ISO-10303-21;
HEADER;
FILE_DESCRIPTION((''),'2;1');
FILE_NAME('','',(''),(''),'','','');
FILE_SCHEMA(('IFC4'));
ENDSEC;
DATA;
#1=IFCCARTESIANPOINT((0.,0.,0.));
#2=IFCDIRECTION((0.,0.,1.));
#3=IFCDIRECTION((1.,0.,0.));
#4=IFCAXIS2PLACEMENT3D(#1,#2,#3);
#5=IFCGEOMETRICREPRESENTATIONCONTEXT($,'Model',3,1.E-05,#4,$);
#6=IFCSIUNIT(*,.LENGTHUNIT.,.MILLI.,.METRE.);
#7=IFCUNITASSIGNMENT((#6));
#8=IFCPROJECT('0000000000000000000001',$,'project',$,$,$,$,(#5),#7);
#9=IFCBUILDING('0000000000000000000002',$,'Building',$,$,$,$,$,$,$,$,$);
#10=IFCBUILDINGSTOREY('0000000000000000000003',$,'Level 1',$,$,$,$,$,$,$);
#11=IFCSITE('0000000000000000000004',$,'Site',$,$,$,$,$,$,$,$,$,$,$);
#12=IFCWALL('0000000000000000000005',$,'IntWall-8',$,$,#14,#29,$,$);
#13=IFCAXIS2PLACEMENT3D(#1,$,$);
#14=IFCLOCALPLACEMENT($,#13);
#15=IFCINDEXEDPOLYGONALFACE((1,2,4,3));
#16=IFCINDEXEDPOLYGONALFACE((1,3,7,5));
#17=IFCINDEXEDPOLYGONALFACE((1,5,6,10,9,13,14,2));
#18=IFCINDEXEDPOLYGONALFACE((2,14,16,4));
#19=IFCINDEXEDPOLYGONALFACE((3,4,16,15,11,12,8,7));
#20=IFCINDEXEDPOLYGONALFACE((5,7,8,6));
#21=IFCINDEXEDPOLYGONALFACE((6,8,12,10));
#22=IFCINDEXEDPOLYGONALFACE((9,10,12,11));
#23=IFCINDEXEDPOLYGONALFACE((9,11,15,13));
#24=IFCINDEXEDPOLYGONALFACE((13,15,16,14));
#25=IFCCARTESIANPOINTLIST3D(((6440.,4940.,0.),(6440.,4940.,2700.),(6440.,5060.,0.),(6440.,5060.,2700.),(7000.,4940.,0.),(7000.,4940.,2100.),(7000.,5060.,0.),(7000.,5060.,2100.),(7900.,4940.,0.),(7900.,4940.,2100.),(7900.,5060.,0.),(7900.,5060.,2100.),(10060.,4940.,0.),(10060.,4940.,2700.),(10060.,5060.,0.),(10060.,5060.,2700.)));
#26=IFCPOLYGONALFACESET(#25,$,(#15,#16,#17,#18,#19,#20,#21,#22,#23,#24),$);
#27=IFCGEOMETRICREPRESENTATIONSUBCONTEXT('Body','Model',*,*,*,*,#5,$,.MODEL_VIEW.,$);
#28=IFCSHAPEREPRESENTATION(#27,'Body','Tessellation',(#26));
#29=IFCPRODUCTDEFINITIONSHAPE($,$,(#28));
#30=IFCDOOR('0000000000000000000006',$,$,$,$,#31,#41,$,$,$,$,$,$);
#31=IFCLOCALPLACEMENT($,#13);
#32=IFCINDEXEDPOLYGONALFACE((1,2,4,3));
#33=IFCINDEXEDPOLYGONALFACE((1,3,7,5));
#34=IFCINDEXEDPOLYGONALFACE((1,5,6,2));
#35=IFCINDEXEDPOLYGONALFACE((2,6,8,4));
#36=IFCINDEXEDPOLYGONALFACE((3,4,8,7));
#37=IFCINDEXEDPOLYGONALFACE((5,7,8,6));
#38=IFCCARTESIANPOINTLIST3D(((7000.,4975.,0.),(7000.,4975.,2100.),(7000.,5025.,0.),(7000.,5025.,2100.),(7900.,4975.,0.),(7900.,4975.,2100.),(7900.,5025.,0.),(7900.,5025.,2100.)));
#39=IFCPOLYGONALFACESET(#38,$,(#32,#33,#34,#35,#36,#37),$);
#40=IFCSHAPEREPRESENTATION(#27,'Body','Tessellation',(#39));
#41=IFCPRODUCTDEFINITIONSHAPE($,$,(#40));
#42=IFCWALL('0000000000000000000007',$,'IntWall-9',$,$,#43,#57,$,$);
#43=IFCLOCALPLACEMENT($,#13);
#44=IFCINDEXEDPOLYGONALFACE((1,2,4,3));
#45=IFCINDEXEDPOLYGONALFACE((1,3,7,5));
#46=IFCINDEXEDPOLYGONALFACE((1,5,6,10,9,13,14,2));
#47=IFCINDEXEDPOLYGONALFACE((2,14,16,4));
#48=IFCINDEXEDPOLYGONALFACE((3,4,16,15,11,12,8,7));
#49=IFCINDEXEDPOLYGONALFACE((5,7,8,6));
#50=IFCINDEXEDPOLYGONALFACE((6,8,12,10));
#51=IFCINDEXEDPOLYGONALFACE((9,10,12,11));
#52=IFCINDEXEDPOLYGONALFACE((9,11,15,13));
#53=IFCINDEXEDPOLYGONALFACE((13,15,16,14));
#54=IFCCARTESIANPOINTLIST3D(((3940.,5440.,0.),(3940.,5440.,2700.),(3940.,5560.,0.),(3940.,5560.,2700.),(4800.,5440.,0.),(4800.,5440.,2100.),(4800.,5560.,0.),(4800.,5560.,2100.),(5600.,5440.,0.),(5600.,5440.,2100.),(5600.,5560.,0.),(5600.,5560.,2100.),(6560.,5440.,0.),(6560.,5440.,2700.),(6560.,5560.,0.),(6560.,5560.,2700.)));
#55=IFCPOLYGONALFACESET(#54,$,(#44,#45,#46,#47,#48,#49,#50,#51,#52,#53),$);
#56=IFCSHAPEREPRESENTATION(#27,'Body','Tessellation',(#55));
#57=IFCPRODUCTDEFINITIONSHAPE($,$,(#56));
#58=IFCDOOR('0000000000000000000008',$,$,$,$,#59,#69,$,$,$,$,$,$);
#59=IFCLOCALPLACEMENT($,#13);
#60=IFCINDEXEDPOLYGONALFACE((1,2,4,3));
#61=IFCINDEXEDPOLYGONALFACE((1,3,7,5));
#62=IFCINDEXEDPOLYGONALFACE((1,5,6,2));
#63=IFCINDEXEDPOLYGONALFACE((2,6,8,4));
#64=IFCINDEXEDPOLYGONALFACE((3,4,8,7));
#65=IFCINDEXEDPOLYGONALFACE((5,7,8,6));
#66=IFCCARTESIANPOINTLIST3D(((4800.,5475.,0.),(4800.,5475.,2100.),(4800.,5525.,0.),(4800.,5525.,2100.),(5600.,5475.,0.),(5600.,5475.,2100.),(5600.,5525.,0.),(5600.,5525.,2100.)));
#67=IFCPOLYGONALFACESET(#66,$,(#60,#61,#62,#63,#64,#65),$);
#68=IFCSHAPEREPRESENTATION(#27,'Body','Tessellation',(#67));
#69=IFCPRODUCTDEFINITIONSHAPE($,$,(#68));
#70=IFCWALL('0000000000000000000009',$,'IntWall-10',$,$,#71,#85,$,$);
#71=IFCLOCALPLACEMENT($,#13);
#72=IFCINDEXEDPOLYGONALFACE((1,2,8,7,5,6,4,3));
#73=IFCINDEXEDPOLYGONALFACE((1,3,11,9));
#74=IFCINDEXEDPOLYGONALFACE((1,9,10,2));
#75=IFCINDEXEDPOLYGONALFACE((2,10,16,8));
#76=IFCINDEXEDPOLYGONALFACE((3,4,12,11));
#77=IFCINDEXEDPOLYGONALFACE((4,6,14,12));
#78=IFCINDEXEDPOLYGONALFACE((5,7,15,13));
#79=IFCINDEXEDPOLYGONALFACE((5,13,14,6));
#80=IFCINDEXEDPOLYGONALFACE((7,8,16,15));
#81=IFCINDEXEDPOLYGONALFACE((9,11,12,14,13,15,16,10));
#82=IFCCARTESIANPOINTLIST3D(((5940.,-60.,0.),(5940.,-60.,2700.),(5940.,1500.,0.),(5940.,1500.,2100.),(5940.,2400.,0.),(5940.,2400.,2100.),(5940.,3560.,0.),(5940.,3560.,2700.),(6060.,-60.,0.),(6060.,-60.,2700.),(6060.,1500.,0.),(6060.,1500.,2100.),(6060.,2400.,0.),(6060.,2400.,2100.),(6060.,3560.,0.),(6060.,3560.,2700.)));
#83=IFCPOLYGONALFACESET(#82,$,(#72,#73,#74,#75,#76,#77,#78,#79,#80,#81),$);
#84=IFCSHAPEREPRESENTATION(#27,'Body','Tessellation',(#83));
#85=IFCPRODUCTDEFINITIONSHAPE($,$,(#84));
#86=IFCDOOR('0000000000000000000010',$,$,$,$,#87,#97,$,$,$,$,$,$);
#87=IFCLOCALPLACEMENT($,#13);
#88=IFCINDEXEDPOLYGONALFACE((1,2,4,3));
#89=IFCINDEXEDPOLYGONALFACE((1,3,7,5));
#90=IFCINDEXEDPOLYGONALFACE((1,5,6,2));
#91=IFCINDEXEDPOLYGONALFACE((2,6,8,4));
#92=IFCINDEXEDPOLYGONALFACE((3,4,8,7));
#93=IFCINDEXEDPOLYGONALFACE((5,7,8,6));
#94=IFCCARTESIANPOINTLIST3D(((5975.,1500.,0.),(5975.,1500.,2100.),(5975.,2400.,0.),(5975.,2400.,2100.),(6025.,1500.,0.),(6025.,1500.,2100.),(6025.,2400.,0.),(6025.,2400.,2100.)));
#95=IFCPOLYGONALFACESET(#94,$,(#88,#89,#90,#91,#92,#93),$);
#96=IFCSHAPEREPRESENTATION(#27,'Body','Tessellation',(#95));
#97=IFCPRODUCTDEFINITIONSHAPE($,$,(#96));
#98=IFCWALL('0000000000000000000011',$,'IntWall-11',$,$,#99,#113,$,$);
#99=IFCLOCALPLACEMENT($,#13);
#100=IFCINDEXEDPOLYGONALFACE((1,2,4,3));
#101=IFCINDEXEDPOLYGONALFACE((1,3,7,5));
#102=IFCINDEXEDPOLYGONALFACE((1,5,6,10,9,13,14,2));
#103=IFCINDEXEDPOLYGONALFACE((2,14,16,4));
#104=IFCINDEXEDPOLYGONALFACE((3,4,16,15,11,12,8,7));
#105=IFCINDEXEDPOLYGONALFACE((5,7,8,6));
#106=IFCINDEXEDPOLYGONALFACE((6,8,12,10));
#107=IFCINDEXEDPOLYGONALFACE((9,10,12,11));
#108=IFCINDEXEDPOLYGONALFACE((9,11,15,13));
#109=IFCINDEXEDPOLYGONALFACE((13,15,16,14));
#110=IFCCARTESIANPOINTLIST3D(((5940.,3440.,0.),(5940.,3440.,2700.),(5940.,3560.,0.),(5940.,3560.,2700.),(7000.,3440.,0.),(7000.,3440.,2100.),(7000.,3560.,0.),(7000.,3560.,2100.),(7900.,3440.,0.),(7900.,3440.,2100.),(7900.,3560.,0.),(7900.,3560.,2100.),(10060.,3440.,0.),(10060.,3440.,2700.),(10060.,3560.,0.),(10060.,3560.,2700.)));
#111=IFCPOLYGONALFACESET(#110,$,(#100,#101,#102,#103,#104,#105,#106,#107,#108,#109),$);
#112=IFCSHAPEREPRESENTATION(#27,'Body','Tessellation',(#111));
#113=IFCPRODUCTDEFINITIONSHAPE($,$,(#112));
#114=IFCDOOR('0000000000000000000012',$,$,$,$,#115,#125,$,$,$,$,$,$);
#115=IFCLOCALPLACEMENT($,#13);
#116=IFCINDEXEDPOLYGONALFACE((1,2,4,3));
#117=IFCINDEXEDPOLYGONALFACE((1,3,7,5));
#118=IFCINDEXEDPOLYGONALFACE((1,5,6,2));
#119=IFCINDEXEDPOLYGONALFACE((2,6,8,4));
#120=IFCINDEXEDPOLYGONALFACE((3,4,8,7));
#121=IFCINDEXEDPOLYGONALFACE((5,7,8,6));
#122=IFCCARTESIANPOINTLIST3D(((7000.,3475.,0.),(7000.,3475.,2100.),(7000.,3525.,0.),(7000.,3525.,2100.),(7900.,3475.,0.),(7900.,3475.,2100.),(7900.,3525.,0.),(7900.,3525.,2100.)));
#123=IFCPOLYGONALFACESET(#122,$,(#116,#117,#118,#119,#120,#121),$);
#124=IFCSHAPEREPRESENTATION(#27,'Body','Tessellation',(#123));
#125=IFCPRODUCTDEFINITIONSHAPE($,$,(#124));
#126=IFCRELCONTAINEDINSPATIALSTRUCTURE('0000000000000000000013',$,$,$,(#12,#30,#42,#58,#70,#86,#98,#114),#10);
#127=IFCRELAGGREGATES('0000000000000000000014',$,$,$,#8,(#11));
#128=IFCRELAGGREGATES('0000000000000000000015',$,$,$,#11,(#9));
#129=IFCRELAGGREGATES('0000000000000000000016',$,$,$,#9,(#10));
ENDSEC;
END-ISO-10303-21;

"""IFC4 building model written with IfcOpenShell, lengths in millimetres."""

from ifc_helpers import new_model, si_unit, frame, origin_with_axes, place, context, subcontext, project, spatial, indexed_curve, outline, extrude, element, fill, save


model = new_model("IFC4")

# Units and contexts
model_context = context("Model", 3, precision=1e-05, world=origin_with_axes())
body_context = subcontext(model_context, "Body", "Model", "MODEL_VIEW")
ifc_project = project(units=[si_unit("LENGTHUNIT", "METRE", prefix="MILLI")], contexts=[model_context])

# Site, building, storey
site = spatial("IfcSite", under=ifc_project, Name="Site")
building = spatial("IfcBuilding", under=site, Name="Building")
storey = spatial("IfcBuildingStorey", under=building, Name="Level 1")

# Walls, openings, doors
wall_1_placement = place(None, frame((6440.0, 5000.0, 0.0), z_axis=(0.0, 0.0, 1.0), x_axis=(1.0, 0.0, 0.0)))
wall_1 = element("IfcWall", 1, at=wall_1_placement, inside=storey, Name="IntWall-8", context=body_context, shape_type="SweptSolid", body=[
    extrude(outline(indexed_curve([(0.0, 0.0), (0.0, 120.0), (3620.0, 120.0), (3620.0, 0.0), (0.0, 0.0)], self_intersect=False)), frame((0.0, -60.0, 0.0), z_axis=(0.0, 0.0, 1.0), x_axis=(1.0, 0.0, 0.0)), (0.0, 0.0, 1.0), 2700.0),
])
opening_1_placement = place(wall_1_placement, frame((560.0, 0.0, 0.0), z_axis=(0.0, 0.0, 1.0), x_axis=(1.0, 0.0, 0.0)))
opening_1 = element("IfcOpeningElement", 2, at=opening_1_placement, cuts=wall_1, context=body_context, shape_type="SweptSolid", body=[
    extrude(outline(indexed_curve([(0.0, 0.0), (0.0, 220.0), (900.0, 220.0), (900.0, 0.0), (0.0, 0.0)], self_intersect=False)), frame((0.0, -110.0, 0.0), z_axis=(0.0, 0.0, 1.0), x_axis=(1.0, 0.0, 0.0)), (0.0, 0.0, 1.0), 2100.0),
])
door_1_placement = place(opening_1_placement, origin_with_axes())
door_1 = element("IfcDoor", 3, at=door_1_placement, inside=storey, context=body_context, shape_type="SweptSolid", body=[
    extrude(outline(indexed_curve([(0.0, 0.0), (0.0, 50.0), (900.0, 50.0), (900.0, 0.0), (0.0, 0.0)], self_intersect=False)), frame((0.0, -25.0, 0.0), z_axis=(0.0, 0.0, 1.0), x_axis=(1.0, 0.0, 0.0)), (0.0, 0.0, 1.0), 2100.0),
])
fill(opening_1, door_1)
wall_2_placement = place(None, frame((3940.0, 5500.0, 0.0), z_axis=(0.0, 0.0, 1.0), x_axis=(1.0, 0.0, 0.0)))
wall_2 = element("IfcWall", 4, at=wall_2_placement, inside=storey, Name="IntWall-9", context=body_context, shape_type="SweptSolid", body=[
    extrude(outline(indexed_curve([(0.0, 0.0), (0.0, 120.0), (2620.0, 120.0), (2620.0, 0.0), (0.0, 0.0)], self_intersect=False)), frame((0.0, -60.0, 0.0), z_axis=(0.0, 0.0, 1.0), x_axis=(1.0, 0.0, 0.0)), (0.0, 0.0, 1.0), 2700.0),
])
opening_2_placement = place(wall_2_placement, frame((860.0, 0.0, 0.0), z_axis=(0.0, 0.0, 1.0), x_axis=(1.0, 0.0, 0.0)))
opening_2 = element("IfcOpeningElement", 5, at=opening_2_placement, cuts=wall_2, context=body_context, shape_type="SweptSolid", body=[
    extrude(outline(indexed_curve([(0.0, 0.0), (0.0, 220.0), (800.0, 220.0), (800.0, 0.0), (0.0, 0.0)], self_intersect=False)), frame((0.0, -110.0, 0.0), z_axis=(0.0, 0.0, 1.0), x_axis=(1.0, 0.0, 0.0)), (0.0, 0.0, 1.0), 2100.0),
])
door_2_placement = place(opening_2_placement, origin_with_axes())
door_2 = element("IfcDoor", 6, at=door_2_placement, inside=storey, context=body_context, shape_type="SweptSolid", body=[
    extrude(outline(indexed_curve([(0.0, 0.0), (0.0, 50.0), (800.0, 50.0), (800.0, 0.0), (0.0, 0.0)], self_intersect=False)), frame((0.0, -25.0, 0.0), z_axis=(0.0, 0.0, 1.0), x_axis=(1.0, 0.0, 0.0)), (0.0, 0.0, 1.0), 2100.0),
])
fill(opening_2, door_2)
wall_3_placement = place(None, frame((6000.0, -60.0, 0.0), z_axis=(0.0, 0.0, 1.0), x_axis=(0.0, 1.0, 0.0)))
wall_3 = element("IfcWall", 7, at=wall_3_placement, inside=storey, Name="IntWall-10", context=body_context, shape_type="SweptSolid", body=[
    extrude(outline(indexed_curve([(0.0, 0.0), (0.0, 120.0), (3620.0, 120.0), (3620.0, 0.0), (0.0, 0.0)], self_intersect=False)), frame((0.0, -60.0, 0.0), z_axis=(0.0, 0.0, 1.0), x_axis=(1.0, 0.0, 0.0)), (0.0, 0.0, 1.0), 2700.0),
])
opening_3_placement = place(wall_3_placement, frame((1560.0, 0.0, 0.0), z_axis=(0.0, 0.0, 1.0), x_axis=(1.0, 0.0, 0.0)))
opening_3 = element("IfcOpeningElement", 8, at=opening_3_placement, cuts=wall_3, context=body_context, shape_type="SweptSolid", body=[
    extrude(outline(indexed_curve([(0.0, 0.0), (0.0, 220.0), (900.0, 220.0), (900.0, 0.0), (0.0, 0.0)], self_intersect=False)), frame((0.0, -110.0, 0.0), z_axis=(0.0, 0.0, 1.0), x_axis=(1.0, 0.0, 0.0)), (0.0, 0.0, 1.0), 2100.0),
])
door_3_placement = place(opening_3_placement, origin_with_axes())
door_3 = element("IfcDoor", 9, at=door_3_placement, inside=storey, context=body_context, shape_type="SweptSolid", body=[
    extrude(outline(indexed_curve([(0.0, 0.0), (0.0, 50.0), (900.0, 50.0), (900.0, 0.0), (0.0, 0.0)], self_intersect=False)), frame((0.0, -25.0, 0.0), z_axis=(0.0, 0.0, 1.0), x_axis=(1.0, 0.0, 0.0)), (0.0, 0.0, 1.0), 2100.0),
])
fill(opening_3, door_3)
wall_4_placement = place(None, frame((5940.0, 3500.0, 0.0), z_axis=(0.0, 0.0, 1.0), x_axis=(1.0, 0.0, 0.0)))
wall_4 = element("IfcWall", 10, at=wall_4_placement, inside=storey, Name="IntWall-11", context=body_context, shape_type="SweptSolid", body=[
    extrude(outline(indexed_curve([(0.0, 0.0), (0.0, 120.0), (4120.0, 120.0), (4120.0, 0.0), (0.0, 0.0)], self_intersect=False)), frame((0.0, -60.0, 0.0), z_axis=(0.0, 0.0, 1.0), x_axis=(1.0, 0.0, 0.0)), (0.0, 0.0, 1.0), 2700.0),
])
opening_4_placement = place(wall_4_placement, frame((1060.0, 0.0, 0.0), z_axis=(0.0, 0.0, 1.0), x_axis=(1.0, 0.0, 0.0)))
opening_4 = element("IfcOpeningElement", 11, at=opening_4_placement, cuts=wall_4, context=body_context, shape_type="SweptSolid", body=[
    extrude(outline(indexed_curve([(0.0, 0.0), (0.0, 220.0), (900.0, 220.0), (900.0, 0.0), (0.0, 0.0)], self_intersect=False)), frame((0.0, -110.0, 0.0), z_axis=(0.0, 0.0, 1.0), x_axis=(1.0, 0.0, 0.0)), (0.0, 0.0, 1.0), 2100.0),
])
door_4_placement = place(opening_4_placement, origin_with_axes())
door_4 = element("IfcDoor", 12, at=door_4_placement, inside=storey, context=body_context, shape_type="SweptSolid", body=[
    extrude(outline(indexed_curve([(0.0, 0.0), (0.0, 50.0), (900.0, 50.0), (900.0, 0.0), (0.0, 0.0)], self_intersect=False)), frame((0.0, -25.0, 0.0), z_axis=(0.0, 0.0, 1.0), x_axis=(1.0, 0.0, 0.0)), (0.0, 0.0, 1.0), 2100.0),
])
fill(opening_4, door_4)

save(model, "model.ifc")
